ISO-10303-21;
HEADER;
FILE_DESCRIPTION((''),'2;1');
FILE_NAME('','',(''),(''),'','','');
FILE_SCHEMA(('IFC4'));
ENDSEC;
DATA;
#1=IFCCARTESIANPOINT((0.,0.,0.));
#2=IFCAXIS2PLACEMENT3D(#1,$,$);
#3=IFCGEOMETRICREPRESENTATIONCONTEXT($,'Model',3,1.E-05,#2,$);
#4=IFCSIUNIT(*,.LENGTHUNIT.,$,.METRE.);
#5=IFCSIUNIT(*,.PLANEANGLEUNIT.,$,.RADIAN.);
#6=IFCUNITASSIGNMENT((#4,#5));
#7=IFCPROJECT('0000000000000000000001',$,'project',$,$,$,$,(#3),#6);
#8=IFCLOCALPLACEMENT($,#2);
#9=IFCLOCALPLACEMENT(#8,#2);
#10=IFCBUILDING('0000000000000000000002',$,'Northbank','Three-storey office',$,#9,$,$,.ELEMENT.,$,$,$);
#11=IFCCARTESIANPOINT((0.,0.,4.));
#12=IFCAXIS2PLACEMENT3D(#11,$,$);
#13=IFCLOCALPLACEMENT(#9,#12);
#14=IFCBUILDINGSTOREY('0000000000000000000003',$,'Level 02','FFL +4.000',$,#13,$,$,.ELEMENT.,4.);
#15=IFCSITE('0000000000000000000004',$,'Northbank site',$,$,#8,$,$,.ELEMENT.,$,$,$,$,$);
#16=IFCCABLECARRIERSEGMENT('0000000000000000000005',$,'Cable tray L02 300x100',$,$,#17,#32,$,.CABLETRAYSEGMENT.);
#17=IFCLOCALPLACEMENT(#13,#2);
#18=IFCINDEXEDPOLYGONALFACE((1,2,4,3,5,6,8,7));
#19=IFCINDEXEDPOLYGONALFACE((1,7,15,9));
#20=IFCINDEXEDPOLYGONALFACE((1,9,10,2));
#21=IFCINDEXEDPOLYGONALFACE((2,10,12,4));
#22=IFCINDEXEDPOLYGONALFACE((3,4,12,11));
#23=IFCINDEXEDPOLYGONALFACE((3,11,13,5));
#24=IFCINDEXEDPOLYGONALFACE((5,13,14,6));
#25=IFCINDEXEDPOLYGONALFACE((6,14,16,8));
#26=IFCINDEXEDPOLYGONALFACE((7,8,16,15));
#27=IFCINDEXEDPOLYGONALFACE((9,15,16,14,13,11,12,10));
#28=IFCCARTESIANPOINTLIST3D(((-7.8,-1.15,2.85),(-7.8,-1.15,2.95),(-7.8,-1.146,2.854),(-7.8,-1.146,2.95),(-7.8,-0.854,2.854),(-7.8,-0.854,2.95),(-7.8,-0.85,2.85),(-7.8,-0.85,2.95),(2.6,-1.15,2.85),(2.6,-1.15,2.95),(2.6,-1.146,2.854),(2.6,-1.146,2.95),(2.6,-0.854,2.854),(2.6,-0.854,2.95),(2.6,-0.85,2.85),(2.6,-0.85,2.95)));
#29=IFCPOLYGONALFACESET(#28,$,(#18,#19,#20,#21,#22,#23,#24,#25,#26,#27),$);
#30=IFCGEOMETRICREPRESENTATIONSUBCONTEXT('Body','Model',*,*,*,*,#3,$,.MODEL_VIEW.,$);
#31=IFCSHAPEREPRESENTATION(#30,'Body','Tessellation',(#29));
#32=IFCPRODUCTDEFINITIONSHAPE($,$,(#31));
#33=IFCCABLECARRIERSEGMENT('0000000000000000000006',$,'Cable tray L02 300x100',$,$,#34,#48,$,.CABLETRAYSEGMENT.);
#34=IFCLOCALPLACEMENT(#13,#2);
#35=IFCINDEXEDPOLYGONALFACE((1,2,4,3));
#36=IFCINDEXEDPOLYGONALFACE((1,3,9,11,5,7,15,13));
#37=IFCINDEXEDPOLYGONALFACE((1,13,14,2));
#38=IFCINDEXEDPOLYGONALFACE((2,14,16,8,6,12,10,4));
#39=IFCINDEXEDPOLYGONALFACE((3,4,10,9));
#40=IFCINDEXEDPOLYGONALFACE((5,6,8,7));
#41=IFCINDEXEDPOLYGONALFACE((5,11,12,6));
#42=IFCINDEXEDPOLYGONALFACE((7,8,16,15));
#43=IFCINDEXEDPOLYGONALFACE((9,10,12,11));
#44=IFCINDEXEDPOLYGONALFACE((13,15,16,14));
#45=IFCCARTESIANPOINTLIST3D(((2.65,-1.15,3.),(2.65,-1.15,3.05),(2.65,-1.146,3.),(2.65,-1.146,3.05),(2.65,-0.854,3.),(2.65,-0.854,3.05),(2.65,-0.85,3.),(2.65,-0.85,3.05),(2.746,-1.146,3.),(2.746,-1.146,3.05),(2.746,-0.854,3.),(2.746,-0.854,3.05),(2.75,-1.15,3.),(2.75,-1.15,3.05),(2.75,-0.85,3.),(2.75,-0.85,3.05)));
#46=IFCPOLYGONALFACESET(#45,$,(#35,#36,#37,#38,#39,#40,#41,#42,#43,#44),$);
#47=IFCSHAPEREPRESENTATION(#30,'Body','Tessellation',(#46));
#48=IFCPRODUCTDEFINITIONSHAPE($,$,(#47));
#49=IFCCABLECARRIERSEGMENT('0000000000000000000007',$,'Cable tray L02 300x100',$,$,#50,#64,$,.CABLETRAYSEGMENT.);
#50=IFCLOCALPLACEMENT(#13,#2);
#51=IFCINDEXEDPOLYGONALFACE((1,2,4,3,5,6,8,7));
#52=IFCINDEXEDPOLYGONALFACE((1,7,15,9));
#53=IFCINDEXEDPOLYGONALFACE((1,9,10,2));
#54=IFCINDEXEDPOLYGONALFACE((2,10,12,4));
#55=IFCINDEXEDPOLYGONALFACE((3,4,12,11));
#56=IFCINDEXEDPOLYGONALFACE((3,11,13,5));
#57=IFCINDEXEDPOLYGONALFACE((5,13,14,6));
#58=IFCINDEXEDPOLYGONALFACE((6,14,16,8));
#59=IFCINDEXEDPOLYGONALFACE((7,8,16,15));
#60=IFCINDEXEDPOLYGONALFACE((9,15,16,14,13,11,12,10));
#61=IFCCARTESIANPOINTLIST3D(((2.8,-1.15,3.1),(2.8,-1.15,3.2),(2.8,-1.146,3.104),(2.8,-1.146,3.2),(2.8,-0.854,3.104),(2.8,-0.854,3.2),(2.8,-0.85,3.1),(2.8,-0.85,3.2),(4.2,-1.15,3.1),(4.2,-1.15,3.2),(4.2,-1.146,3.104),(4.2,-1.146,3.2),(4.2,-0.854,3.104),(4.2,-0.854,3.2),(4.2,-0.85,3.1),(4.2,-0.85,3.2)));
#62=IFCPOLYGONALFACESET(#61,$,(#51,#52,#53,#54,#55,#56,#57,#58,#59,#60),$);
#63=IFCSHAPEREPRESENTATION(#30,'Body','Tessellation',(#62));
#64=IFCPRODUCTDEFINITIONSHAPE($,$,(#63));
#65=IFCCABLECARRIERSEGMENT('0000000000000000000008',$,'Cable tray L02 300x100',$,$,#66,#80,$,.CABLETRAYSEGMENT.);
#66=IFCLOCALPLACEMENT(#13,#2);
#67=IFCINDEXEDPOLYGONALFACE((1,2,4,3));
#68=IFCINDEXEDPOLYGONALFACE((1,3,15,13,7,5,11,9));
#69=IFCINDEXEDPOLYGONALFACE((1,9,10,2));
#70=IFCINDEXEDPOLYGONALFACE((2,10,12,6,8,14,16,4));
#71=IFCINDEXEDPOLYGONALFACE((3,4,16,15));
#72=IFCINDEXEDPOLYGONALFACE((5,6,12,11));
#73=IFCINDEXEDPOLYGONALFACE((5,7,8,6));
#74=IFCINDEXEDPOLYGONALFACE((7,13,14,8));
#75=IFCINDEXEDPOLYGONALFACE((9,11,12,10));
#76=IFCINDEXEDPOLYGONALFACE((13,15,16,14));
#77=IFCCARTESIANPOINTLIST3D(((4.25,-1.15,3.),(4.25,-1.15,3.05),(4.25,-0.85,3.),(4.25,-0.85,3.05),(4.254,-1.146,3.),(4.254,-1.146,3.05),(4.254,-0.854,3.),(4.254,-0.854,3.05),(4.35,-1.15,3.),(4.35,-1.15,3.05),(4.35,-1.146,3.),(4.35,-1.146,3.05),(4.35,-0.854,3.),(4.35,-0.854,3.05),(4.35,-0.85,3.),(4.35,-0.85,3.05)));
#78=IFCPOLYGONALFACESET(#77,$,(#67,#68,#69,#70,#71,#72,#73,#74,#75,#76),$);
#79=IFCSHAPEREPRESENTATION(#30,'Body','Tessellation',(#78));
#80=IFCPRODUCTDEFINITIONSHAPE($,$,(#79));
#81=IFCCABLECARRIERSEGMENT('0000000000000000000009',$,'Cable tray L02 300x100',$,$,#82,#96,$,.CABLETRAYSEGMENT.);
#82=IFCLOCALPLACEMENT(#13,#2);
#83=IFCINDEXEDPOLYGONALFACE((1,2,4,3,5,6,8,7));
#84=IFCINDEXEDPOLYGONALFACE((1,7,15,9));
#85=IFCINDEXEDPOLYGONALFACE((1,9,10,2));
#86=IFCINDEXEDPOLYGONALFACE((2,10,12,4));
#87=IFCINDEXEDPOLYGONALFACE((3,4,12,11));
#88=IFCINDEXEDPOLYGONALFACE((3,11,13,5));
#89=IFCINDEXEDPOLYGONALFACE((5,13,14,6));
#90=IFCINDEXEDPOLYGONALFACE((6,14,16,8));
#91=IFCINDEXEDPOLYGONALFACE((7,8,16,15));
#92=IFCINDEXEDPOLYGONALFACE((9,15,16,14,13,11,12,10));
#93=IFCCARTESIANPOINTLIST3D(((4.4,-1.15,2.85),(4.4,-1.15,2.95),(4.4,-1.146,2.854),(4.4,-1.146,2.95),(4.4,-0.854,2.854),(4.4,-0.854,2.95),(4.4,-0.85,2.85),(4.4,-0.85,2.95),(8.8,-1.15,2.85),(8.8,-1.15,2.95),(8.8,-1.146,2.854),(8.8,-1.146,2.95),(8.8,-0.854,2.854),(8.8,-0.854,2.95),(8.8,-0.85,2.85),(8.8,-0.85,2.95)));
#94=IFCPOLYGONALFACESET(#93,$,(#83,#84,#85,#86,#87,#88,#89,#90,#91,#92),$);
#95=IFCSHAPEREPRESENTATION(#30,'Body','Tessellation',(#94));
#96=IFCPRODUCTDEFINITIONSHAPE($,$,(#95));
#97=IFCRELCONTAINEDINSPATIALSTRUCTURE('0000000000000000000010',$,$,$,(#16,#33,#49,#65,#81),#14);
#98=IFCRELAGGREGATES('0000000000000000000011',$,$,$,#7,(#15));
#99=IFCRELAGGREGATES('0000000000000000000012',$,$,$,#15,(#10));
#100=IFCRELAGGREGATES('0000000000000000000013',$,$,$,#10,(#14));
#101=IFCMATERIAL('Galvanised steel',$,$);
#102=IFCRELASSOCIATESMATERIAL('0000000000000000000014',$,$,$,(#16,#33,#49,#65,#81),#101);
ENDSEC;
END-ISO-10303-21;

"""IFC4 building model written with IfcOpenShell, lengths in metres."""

from ifc_helpers import new_model, si_unit, frame, origin, place, context, subcontext, project, spatial, u_section, extrude, material, element, save


model = new_model("IFC4")

# Units and contexts
model_context = context("Model", 3, precision=1e-05, world=origin())
body_context = subcontext(model_context, "Body", "Model", "MODEL_VIEW")
ifc_project = project(units=[si_unit("LENGTHUNIT", "METRE"), si_unit("PLANEANGLEUNIT", "RADIAN")], contexts=[model_context])

# Site, building, storey
site_placement = place(None, origin())
site = spatial("IfcSite", under=ifc_project, at=site_placement, Name="Northbank site", CompositionType="ELEMENT")
building_placement = place(site_placement, origin())
building = spatial("IfcBuilding", under=site, at=building_placement, Name="Northbank", Description="Three-storey office", CompositionType="ELEMENT")
storey_placement = place(building_placement, frame((0.0, 0.0, 4.0)))
storey = spatial("IfcBuildingStorey", under=building, at=storey_placement, Name="Level 02", Description="FFL +4.000", CompositionType="ELEMENT", Elevation=4.0)

# Shared definitions
ifc_material_1 = material(Name="Galvanised steel")

# Cable carrier segments
cable_carrier_segment_1_placement = place(storey_placement, frame((0.0, 0.0, -4.0)))
element("IfcCableCarrierSegment", 1, at=cable_carrier_segment_1_placement, inside=storey, material=ifc_material_1, Name="Cable tray L02 300x100", PredefinedType="CABLETRAYSEGMENT", context=body_context, shape_type="SweptSolid", body=[
    extrude(u_section(Depth=0.3, FlangeWidth=0.1, WebThickness=0.004, FlangeThickness=0.004), frame((-7.8, -1.0, 6.9), z_axis=(1.0, 0.0, 0.0), x_axis=(0.0, 0.0, 1.0)), (0.0, 0.0, 1.0), 10.4),
])
cable_carrier_segment_2_placement = place(storey_placement, frame((0.0, 0.0, -4.0)))
element("IfcCableCarrierSegment", 2, at=cable_carrier_segment_2_placement, inside=storey, material=ifc_material_1, Name="Cable tray L02 300x100", PredefinedType="CABLETRAYSEGMENT", context=body_context, shape_type="SweptSolid", body=[
    extrude(u_section(Depth=0.3, FlangeWidth=0.1, WebThickness=0.004, FlangeThickness=0.004), frame((2.7, -1.0, 7.0), z_axis=(0.0, 0.0, 1.0), x_axis=(-1.0, 0.0, 0.0)), (0.0, 0.0, 1.0), 0.05),
])
cable_carrier_segment_3_placement = place(storey_placement, frame((0.0, 0.0, -4.0)))
element("IfcCableCarrierSegment", 3, at=cable_carrier_segment_3_placement, inside=storey, material=ifc_material_1, Name="Cable tray L02 300x100", PredefinedType="CABLETRAYSEGMENT", context=body_context, shape_type="SweptSolid", body=[
    extrude(u_section(Depth=0.3, FlangeWidth=0.1, WebThickness=0.004, FlangeThickness=0.004), frame((2.8, -1.0, 7.15), z_axis=(1.0, 0.0, 0.0), x_axis=(0.0, 0.0, 1.0)), (0.0, 0.0, 1.0), 1.4),
])
cable_carrier_segment_4_placement = place(storey_placement, frame((0.0, 0.0, -4.0)))
element("IfcCableCarrierSegment", 4, at=cable_carrier_segment_4_placement, inside=storey, material=ifc_material_1, Name="Cable tray L02 300x100", PredefinedType="CABLETRAYSEGMENT", context=body_context, shape_type="SweptSolid", body=[
    extrude(u_section(Depth=0.3, FlangeWidth=0.1, WebThickness=0.004, FlangeThickness=0.004), frame((4.3, -1.0, 7.05), z_axis=(0.0, 0.0, -1.0), x_axis=(1.0, 0.0, 0.0)), (0.0, 0.0, 1.0), 0.05),
])
cable_carrier_segment_5_placement = place(storey_placement, frame((0.0, 0.0, -4.0)))
element("IfcCableCarrierSegment", 5, at=cable_carrier_segment_5_placement, inside=storey, material=ifc_material_1, Name="Cable tray L02 300x100", PredefinedType="CABLETRAYSEGMENT", context=body_context, shape_type="SweptSolid", body=[
    extrude(u_section(Depth=0.3, FlangeWidth=0.1, WebThickness=0.004, FlangeThickness=0.004), frame((4.4, -1.0, 6.9), z_axis=(1.0, 0.0, 0.0), x_axis=(0.0, 0.0, 1.0)), (0.0, 0.0, 1.0), 4.4),
])

save(model, "model.ifc")
